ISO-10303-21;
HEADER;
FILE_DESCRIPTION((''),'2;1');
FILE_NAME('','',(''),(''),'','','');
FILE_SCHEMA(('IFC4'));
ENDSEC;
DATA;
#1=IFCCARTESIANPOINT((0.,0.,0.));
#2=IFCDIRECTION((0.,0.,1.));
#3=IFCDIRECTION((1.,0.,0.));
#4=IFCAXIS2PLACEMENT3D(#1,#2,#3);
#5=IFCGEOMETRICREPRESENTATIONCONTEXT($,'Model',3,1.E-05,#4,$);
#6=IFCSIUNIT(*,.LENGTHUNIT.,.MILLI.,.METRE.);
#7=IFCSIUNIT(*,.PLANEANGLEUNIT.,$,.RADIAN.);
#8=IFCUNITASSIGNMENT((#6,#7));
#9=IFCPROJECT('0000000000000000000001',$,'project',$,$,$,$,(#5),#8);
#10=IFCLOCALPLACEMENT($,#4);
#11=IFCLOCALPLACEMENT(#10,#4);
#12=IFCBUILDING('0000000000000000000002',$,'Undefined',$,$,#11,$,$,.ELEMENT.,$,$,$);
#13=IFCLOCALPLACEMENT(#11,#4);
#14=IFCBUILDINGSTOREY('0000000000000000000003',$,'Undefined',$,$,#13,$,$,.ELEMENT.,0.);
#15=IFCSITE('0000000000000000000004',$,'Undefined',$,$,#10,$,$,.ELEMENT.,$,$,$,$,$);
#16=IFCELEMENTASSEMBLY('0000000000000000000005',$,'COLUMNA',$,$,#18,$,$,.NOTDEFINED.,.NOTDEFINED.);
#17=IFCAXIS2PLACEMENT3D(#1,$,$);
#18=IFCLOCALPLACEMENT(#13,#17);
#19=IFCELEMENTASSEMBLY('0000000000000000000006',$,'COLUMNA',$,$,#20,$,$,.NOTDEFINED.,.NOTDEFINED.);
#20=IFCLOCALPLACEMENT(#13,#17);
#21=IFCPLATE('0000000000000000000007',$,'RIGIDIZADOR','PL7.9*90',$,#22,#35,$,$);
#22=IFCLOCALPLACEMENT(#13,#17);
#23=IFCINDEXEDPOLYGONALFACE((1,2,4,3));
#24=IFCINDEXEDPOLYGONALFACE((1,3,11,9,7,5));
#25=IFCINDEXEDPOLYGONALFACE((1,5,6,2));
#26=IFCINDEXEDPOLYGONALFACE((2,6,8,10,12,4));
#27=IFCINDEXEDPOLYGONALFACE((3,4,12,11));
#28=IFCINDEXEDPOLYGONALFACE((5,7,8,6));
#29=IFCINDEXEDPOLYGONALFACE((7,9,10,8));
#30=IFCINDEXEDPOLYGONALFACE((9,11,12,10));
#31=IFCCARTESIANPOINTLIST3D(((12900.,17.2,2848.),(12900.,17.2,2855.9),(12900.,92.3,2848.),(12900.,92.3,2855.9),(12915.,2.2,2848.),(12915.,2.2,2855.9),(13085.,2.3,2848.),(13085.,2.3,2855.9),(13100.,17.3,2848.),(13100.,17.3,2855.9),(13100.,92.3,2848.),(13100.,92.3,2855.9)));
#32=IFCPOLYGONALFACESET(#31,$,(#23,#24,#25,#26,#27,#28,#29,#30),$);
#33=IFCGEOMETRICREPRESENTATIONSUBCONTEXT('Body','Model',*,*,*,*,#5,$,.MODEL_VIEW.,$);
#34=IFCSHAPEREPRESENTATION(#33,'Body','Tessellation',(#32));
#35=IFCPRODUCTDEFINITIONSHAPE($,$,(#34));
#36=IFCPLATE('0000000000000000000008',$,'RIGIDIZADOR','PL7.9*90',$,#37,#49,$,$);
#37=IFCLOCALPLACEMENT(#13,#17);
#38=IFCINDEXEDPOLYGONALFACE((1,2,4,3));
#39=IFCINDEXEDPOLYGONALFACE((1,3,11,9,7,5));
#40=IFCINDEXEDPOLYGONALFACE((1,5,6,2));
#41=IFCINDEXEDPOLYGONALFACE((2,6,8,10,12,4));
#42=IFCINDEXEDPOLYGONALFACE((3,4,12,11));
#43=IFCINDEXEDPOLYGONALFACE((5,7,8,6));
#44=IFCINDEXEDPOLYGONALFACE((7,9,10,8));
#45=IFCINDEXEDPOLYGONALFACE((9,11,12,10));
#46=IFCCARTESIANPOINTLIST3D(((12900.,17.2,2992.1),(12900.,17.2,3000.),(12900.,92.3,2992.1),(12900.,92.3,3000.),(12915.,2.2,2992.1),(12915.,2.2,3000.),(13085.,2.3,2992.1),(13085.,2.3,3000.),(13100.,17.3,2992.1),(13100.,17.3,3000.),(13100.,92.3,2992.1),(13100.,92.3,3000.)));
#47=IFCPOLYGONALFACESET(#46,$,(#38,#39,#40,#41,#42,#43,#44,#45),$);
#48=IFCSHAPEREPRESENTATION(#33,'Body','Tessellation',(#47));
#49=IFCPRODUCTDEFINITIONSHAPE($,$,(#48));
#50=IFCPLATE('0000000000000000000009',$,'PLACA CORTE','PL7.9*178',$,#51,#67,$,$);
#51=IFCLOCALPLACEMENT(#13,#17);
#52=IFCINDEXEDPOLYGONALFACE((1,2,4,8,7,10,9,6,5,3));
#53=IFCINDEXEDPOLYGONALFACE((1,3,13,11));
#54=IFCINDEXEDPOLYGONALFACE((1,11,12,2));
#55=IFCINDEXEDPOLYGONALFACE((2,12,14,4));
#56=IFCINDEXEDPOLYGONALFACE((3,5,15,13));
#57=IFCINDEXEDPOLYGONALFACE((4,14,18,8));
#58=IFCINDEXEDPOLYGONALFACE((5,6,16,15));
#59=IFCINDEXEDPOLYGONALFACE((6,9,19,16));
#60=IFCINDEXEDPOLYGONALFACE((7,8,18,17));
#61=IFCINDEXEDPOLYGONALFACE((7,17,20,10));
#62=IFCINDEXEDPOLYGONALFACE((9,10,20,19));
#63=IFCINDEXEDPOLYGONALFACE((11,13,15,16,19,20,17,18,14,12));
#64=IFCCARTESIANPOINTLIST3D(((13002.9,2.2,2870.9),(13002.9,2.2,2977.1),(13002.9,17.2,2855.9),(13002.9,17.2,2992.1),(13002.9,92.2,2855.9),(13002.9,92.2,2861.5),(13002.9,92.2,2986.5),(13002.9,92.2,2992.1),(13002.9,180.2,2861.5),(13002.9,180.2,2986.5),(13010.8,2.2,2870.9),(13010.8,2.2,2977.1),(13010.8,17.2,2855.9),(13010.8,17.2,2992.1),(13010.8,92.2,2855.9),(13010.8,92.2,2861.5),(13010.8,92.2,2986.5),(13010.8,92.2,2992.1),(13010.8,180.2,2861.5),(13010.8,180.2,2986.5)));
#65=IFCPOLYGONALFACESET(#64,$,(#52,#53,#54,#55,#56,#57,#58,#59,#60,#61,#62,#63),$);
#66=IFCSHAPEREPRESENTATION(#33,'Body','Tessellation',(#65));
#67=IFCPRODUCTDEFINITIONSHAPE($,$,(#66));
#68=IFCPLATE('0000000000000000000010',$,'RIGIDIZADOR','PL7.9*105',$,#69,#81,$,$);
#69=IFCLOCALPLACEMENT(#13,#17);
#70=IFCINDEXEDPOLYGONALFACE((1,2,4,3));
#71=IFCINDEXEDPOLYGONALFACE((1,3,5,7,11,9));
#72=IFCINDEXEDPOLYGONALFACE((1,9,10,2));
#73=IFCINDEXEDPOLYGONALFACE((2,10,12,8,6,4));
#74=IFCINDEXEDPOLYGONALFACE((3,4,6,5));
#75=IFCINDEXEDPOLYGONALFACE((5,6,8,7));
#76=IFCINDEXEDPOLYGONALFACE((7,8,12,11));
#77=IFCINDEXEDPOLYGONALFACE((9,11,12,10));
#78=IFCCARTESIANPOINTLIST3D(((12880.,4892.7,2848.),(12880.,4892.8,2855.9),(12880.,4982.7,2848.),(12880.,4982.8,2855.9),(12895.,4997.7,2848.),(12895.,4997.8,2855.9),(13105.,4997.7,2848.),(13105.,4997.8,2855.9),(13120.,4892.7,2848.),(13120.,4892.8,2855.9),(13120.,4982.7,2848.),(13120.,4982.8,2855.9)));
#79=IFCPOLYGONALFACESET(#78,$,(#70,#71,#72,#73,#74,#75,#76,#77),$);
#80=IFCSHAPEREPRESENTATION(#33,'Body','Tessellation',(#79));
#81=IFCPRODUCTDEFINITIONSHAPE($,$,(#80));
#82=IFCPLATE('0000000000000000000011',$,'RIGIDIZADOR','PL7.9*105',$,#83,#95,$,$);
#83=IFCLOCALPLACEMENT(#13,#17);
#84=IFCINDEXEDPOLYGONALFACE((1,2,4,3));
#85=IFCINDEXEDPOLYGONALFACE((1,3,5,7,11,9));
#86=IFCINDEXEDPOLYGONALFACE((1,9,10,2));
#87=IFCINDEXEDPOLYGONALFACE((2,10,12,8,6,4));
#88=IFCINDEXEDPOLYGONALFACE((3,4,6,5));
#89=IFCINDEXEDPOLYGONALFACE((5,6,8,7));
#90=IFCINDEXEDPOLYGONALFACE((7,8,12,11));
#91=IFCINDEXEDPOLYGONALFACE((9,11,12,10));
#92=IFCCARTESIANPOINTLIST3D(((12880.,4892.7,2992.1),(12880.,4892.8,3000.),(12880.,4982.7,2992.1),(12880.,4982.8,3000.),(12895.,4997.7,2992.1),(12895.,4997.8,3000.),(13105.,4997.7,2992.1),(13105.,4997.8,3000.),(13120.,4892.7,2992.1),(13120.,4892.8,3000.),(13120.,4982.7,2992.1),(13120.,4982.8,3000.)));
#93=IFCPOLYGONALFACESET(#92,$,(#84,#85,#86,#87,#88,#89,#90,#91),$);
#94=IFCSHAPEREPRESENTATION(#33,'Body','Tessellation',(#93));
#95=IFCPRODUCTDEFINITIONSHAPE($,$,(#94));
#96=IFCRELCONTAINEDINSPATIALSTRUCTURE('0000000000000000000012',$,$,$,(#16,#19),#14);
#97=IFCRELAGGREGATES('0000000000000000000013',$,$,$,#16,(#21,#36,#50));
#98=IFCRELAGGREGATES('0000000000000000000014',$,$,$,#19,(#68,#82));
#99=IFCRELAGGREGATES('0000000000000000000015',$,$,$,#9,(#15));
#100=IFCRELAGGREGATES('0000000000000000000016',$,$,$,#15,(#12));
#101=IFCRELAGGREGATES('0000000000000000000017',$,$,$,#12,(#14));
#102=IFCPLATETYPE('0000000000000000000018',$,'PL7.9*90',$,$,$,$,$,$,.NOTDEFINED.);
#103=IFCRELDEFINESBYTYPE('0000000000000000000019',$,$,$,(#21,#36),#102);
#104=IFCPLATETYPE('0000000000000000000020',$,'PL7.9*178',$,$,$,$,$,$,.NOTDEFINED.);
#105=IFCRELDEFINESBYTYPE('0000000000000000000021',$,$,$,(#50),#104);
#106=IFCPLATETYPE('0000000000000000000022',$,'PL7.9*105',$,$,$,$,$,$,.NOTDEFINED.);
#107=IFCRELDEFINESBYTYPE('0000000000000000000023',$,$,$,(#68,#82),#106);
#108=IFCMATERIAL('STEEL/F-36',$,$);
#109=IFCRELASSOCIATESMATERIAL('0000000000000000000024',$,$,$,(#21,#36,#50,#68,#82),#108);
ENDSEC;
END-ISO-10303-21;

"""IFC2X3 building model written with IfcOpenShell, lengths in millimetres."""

from ifc_helpers import new_model, si_unit, frame, origin_with_axes, place, context, subcontext, project, spatial, polyline, outline, extrude, material, type_object, element, aggregate, save


model = new_model("IFC2X3")

# Units and contexts
model_context = context("Model", 3, precision=1e-05, world=origin_with_axes())
body_context = subcontext(model_context, "Body", "Model", "MODEL_VIEW")
ifc_project = project(units=[si_unit("LENGTHUNIT", "METRE", prefix="MILLI"), si_unit("PLANEANGLEUNIT", "RADIAN")], contexts=[model_context])

# Site, building, storey
site_placement = place(None, origin_with_axes())
site = spatial("IfcSite", under=ifc_project, at=site_placement, Name="Undefined", CompositionType="ELEMENT")
building_placement = place(site_placement, origin_with_axes())
building = spatial("IfcBuilding", under=site, at=building_placement, Name="Undefined", CompositionType="ELEMENT")
storey_placement = place(building_placement, origin_with_axes())
storey = spatial("IfcBuildingStorey", under=building, at=storey_placement, Name="Undefined", CompositionType="ELEMENT", Elevation=0.0)

# Element assemblies
ifc_material_1 = material(Name="STEEL/F-36")
assembly_1_placement = place(storey_placement, origin_with_axes())
assembly_1 = element("IfcElementAssembly", 1, at=assembly_1_placement, inside=storey, Name="COLUMNA", AssemblyPlace="NOTDEFINED", PredefinedType="NOTDEFINED")
assembly_2_placement = place(storey_placement, origin_with_axes())
assembly_2 = element("IfcElementAssembly", 2, at=assembly_2_placement, inside=storey, Name="COLUMNA", AssemblyPlace="NOTDEFINED", PredefinedType="NOTDEFINED")

# Plates
plate_type_1 = type_object("IfcPlateType", Name="PL7.9*90", PredefinedType="NOTDEFINED")
plate_1_placement = place(assembly_1_placement, frame((13100.0, 2.3, 2851.9), z_axis=(0.0, 0.0, 1.0), x_axis=(0.0, 1.0, 0.0)))
plate_1 = element("IfcPlate", 3, at=plate_1_placement, type_object=plate_type_1, material=ifc_material_1, Name="RIGIDIZADOR", Description="PL7.9*90", context=body_context, shape_type="SweptSolid", body=[
    extrude(outline(polyline([(0.0, 15.0), (15.0, 0.0), (90.0, 0.0), (90.0, 200.0), (15.0, 200.0), (0.0, 185.0), (0.0, 15.0)])), frame((0.0, 0.0, -4.0), z_axis=(0.0, 0.0, 1.0), x_axis=(1.0, 0.0, 0.0)), (0.0, 0.0, 1.0), 7.9),
])
plate_2_placement = place(assembly_1_placement, frame((13100.0, 2.3, 2996.1), z_axis=(0.0, 0.0, 1.0), x_axis=(0.0, 1.0, 0.0)))
plate_2 = element("IfcPlate", 4, at=plate_2_placement, type_object=plate_type_1, material=ifc_material_1, Name="RIGIDIZADOR", Description="PL7.9*90", context=body_context, shape_type="SweptSolid", body=[
    extrude(outline(polyline([(0.0, 15.0), (15.0, 0.0), (90.0, 0.0), (90.0, 200.0), (15.0, 200.0), (0.0, 185.0), (0.0, 15.0)])), frame((0.0, 0.0, -4.0), z_axis=(0.0, 0.0, 1.0), x_axis=(1.0, 0.0, 0.0)), (0.0, 0.0, 1.0), 7.9),
])
plate_type_2 = type_object("IfcPlateType", Name="PL7.9*178", PredefinedType="NOTDEFINED")
plate_3_placement = place(assembly_1_placement, frame((13006.8, 2.2, 2992.1), z_axis=(1.0, 0.0, 0.0), x_axis=(0.0, 0.0, -1.0)))
plate_3 = element("IfcPlate", 5, at=plate_3_placement, type_object=plate_type_2, material=ifc_material_1, Name="PLACA CORTE", Description="PL7.9*178", context=body_context, shape_type="SweptSolid", body=[
    extrude(outline(polyline([(0.0, 15.0), (15.0, 0.0), (121.2, 0.0), (136.2, 15.0), (136.2, 90.0), (130.6, 90.0), (130.6, 178.0), (5.6, 178.0), (5.6, 90.0), (0.0, 90.0), (0.0, 15.0)])), frame((0.0, 0.0, -4.0), z_axis=(0.0, 0.0, 1.0), x_axis=(1.0, 0.0, 0.0)), (0.0, 0.0, 1.0), 7.9),
])
aggregate(assembly_1, [plate_1, plate_2, plate_3])
plate_type_3 = type_object("IfcPlateType", Name="PL7.9*105", PredefinedType="NOTDEFINED")
plate_4_placement = place(assembly_2_placement, frame((13120.0, 4997.7, 2851.9), z_axis=(0.0, 0.0, -1.0), x_axis=(0.0, -1.0, 0.0)))
plate_4 = element("IfcPlate", 6, at=plate_4_placement, type_object=plate_type_3, material=ifc_material_1, Name="RIGIDIZADOR", Description="PL7.9*105", context=body_context, shape_type="SweptSolid", body=[
    extrude(outline(polyline([(0.0, 15.0), (15.0, 0.0), (105.0, 0.0), (105.0, 240.0), (15.0, 240.0), (0.0, 225.0), (0.0, 15.0)])), frame((0.0, 0.0, -4.0), z_axis=(0.0, 0.0, 1.0), x_axis=(1.0, 0.0, 0.0)), (0.0, 0.0, 1.0), 7.9),
])
plate_5_placement = place(assembly_2_placement, frame((13120.0, 4997.7, 2996.1), z_axis=(0.0, 0.0, -1.0), x_axis=(0.0, -1.0, 0.0)))
plate_5 = element("IfcPlate", 7, at=plate_5_placement, type_object=plate_type_3, material=ifc_material_1, Name="RIGIDIZADOR", Description="PL7.9*105", context=body_context, shape_type="SweptSolid", body=[
    extrude(outline(polyline([(0.0, 15.0), (15.0, 0.0), (105.0, 0.0), (105.0, 240.0), (15.0, 240.0), (0.0, 225.0), (0.0, 15.0)])), frame((0.0, 0.0, -4.0), z_axis=(0.0, 0.0, 1.0), x_axis=(1.0, 0.0, 0.0)), (0.0, 0.0, 1.0), 7.9),
])
aggregate(assembly_2, [plate_4, plate_5])

save(model, "model.ifc")
